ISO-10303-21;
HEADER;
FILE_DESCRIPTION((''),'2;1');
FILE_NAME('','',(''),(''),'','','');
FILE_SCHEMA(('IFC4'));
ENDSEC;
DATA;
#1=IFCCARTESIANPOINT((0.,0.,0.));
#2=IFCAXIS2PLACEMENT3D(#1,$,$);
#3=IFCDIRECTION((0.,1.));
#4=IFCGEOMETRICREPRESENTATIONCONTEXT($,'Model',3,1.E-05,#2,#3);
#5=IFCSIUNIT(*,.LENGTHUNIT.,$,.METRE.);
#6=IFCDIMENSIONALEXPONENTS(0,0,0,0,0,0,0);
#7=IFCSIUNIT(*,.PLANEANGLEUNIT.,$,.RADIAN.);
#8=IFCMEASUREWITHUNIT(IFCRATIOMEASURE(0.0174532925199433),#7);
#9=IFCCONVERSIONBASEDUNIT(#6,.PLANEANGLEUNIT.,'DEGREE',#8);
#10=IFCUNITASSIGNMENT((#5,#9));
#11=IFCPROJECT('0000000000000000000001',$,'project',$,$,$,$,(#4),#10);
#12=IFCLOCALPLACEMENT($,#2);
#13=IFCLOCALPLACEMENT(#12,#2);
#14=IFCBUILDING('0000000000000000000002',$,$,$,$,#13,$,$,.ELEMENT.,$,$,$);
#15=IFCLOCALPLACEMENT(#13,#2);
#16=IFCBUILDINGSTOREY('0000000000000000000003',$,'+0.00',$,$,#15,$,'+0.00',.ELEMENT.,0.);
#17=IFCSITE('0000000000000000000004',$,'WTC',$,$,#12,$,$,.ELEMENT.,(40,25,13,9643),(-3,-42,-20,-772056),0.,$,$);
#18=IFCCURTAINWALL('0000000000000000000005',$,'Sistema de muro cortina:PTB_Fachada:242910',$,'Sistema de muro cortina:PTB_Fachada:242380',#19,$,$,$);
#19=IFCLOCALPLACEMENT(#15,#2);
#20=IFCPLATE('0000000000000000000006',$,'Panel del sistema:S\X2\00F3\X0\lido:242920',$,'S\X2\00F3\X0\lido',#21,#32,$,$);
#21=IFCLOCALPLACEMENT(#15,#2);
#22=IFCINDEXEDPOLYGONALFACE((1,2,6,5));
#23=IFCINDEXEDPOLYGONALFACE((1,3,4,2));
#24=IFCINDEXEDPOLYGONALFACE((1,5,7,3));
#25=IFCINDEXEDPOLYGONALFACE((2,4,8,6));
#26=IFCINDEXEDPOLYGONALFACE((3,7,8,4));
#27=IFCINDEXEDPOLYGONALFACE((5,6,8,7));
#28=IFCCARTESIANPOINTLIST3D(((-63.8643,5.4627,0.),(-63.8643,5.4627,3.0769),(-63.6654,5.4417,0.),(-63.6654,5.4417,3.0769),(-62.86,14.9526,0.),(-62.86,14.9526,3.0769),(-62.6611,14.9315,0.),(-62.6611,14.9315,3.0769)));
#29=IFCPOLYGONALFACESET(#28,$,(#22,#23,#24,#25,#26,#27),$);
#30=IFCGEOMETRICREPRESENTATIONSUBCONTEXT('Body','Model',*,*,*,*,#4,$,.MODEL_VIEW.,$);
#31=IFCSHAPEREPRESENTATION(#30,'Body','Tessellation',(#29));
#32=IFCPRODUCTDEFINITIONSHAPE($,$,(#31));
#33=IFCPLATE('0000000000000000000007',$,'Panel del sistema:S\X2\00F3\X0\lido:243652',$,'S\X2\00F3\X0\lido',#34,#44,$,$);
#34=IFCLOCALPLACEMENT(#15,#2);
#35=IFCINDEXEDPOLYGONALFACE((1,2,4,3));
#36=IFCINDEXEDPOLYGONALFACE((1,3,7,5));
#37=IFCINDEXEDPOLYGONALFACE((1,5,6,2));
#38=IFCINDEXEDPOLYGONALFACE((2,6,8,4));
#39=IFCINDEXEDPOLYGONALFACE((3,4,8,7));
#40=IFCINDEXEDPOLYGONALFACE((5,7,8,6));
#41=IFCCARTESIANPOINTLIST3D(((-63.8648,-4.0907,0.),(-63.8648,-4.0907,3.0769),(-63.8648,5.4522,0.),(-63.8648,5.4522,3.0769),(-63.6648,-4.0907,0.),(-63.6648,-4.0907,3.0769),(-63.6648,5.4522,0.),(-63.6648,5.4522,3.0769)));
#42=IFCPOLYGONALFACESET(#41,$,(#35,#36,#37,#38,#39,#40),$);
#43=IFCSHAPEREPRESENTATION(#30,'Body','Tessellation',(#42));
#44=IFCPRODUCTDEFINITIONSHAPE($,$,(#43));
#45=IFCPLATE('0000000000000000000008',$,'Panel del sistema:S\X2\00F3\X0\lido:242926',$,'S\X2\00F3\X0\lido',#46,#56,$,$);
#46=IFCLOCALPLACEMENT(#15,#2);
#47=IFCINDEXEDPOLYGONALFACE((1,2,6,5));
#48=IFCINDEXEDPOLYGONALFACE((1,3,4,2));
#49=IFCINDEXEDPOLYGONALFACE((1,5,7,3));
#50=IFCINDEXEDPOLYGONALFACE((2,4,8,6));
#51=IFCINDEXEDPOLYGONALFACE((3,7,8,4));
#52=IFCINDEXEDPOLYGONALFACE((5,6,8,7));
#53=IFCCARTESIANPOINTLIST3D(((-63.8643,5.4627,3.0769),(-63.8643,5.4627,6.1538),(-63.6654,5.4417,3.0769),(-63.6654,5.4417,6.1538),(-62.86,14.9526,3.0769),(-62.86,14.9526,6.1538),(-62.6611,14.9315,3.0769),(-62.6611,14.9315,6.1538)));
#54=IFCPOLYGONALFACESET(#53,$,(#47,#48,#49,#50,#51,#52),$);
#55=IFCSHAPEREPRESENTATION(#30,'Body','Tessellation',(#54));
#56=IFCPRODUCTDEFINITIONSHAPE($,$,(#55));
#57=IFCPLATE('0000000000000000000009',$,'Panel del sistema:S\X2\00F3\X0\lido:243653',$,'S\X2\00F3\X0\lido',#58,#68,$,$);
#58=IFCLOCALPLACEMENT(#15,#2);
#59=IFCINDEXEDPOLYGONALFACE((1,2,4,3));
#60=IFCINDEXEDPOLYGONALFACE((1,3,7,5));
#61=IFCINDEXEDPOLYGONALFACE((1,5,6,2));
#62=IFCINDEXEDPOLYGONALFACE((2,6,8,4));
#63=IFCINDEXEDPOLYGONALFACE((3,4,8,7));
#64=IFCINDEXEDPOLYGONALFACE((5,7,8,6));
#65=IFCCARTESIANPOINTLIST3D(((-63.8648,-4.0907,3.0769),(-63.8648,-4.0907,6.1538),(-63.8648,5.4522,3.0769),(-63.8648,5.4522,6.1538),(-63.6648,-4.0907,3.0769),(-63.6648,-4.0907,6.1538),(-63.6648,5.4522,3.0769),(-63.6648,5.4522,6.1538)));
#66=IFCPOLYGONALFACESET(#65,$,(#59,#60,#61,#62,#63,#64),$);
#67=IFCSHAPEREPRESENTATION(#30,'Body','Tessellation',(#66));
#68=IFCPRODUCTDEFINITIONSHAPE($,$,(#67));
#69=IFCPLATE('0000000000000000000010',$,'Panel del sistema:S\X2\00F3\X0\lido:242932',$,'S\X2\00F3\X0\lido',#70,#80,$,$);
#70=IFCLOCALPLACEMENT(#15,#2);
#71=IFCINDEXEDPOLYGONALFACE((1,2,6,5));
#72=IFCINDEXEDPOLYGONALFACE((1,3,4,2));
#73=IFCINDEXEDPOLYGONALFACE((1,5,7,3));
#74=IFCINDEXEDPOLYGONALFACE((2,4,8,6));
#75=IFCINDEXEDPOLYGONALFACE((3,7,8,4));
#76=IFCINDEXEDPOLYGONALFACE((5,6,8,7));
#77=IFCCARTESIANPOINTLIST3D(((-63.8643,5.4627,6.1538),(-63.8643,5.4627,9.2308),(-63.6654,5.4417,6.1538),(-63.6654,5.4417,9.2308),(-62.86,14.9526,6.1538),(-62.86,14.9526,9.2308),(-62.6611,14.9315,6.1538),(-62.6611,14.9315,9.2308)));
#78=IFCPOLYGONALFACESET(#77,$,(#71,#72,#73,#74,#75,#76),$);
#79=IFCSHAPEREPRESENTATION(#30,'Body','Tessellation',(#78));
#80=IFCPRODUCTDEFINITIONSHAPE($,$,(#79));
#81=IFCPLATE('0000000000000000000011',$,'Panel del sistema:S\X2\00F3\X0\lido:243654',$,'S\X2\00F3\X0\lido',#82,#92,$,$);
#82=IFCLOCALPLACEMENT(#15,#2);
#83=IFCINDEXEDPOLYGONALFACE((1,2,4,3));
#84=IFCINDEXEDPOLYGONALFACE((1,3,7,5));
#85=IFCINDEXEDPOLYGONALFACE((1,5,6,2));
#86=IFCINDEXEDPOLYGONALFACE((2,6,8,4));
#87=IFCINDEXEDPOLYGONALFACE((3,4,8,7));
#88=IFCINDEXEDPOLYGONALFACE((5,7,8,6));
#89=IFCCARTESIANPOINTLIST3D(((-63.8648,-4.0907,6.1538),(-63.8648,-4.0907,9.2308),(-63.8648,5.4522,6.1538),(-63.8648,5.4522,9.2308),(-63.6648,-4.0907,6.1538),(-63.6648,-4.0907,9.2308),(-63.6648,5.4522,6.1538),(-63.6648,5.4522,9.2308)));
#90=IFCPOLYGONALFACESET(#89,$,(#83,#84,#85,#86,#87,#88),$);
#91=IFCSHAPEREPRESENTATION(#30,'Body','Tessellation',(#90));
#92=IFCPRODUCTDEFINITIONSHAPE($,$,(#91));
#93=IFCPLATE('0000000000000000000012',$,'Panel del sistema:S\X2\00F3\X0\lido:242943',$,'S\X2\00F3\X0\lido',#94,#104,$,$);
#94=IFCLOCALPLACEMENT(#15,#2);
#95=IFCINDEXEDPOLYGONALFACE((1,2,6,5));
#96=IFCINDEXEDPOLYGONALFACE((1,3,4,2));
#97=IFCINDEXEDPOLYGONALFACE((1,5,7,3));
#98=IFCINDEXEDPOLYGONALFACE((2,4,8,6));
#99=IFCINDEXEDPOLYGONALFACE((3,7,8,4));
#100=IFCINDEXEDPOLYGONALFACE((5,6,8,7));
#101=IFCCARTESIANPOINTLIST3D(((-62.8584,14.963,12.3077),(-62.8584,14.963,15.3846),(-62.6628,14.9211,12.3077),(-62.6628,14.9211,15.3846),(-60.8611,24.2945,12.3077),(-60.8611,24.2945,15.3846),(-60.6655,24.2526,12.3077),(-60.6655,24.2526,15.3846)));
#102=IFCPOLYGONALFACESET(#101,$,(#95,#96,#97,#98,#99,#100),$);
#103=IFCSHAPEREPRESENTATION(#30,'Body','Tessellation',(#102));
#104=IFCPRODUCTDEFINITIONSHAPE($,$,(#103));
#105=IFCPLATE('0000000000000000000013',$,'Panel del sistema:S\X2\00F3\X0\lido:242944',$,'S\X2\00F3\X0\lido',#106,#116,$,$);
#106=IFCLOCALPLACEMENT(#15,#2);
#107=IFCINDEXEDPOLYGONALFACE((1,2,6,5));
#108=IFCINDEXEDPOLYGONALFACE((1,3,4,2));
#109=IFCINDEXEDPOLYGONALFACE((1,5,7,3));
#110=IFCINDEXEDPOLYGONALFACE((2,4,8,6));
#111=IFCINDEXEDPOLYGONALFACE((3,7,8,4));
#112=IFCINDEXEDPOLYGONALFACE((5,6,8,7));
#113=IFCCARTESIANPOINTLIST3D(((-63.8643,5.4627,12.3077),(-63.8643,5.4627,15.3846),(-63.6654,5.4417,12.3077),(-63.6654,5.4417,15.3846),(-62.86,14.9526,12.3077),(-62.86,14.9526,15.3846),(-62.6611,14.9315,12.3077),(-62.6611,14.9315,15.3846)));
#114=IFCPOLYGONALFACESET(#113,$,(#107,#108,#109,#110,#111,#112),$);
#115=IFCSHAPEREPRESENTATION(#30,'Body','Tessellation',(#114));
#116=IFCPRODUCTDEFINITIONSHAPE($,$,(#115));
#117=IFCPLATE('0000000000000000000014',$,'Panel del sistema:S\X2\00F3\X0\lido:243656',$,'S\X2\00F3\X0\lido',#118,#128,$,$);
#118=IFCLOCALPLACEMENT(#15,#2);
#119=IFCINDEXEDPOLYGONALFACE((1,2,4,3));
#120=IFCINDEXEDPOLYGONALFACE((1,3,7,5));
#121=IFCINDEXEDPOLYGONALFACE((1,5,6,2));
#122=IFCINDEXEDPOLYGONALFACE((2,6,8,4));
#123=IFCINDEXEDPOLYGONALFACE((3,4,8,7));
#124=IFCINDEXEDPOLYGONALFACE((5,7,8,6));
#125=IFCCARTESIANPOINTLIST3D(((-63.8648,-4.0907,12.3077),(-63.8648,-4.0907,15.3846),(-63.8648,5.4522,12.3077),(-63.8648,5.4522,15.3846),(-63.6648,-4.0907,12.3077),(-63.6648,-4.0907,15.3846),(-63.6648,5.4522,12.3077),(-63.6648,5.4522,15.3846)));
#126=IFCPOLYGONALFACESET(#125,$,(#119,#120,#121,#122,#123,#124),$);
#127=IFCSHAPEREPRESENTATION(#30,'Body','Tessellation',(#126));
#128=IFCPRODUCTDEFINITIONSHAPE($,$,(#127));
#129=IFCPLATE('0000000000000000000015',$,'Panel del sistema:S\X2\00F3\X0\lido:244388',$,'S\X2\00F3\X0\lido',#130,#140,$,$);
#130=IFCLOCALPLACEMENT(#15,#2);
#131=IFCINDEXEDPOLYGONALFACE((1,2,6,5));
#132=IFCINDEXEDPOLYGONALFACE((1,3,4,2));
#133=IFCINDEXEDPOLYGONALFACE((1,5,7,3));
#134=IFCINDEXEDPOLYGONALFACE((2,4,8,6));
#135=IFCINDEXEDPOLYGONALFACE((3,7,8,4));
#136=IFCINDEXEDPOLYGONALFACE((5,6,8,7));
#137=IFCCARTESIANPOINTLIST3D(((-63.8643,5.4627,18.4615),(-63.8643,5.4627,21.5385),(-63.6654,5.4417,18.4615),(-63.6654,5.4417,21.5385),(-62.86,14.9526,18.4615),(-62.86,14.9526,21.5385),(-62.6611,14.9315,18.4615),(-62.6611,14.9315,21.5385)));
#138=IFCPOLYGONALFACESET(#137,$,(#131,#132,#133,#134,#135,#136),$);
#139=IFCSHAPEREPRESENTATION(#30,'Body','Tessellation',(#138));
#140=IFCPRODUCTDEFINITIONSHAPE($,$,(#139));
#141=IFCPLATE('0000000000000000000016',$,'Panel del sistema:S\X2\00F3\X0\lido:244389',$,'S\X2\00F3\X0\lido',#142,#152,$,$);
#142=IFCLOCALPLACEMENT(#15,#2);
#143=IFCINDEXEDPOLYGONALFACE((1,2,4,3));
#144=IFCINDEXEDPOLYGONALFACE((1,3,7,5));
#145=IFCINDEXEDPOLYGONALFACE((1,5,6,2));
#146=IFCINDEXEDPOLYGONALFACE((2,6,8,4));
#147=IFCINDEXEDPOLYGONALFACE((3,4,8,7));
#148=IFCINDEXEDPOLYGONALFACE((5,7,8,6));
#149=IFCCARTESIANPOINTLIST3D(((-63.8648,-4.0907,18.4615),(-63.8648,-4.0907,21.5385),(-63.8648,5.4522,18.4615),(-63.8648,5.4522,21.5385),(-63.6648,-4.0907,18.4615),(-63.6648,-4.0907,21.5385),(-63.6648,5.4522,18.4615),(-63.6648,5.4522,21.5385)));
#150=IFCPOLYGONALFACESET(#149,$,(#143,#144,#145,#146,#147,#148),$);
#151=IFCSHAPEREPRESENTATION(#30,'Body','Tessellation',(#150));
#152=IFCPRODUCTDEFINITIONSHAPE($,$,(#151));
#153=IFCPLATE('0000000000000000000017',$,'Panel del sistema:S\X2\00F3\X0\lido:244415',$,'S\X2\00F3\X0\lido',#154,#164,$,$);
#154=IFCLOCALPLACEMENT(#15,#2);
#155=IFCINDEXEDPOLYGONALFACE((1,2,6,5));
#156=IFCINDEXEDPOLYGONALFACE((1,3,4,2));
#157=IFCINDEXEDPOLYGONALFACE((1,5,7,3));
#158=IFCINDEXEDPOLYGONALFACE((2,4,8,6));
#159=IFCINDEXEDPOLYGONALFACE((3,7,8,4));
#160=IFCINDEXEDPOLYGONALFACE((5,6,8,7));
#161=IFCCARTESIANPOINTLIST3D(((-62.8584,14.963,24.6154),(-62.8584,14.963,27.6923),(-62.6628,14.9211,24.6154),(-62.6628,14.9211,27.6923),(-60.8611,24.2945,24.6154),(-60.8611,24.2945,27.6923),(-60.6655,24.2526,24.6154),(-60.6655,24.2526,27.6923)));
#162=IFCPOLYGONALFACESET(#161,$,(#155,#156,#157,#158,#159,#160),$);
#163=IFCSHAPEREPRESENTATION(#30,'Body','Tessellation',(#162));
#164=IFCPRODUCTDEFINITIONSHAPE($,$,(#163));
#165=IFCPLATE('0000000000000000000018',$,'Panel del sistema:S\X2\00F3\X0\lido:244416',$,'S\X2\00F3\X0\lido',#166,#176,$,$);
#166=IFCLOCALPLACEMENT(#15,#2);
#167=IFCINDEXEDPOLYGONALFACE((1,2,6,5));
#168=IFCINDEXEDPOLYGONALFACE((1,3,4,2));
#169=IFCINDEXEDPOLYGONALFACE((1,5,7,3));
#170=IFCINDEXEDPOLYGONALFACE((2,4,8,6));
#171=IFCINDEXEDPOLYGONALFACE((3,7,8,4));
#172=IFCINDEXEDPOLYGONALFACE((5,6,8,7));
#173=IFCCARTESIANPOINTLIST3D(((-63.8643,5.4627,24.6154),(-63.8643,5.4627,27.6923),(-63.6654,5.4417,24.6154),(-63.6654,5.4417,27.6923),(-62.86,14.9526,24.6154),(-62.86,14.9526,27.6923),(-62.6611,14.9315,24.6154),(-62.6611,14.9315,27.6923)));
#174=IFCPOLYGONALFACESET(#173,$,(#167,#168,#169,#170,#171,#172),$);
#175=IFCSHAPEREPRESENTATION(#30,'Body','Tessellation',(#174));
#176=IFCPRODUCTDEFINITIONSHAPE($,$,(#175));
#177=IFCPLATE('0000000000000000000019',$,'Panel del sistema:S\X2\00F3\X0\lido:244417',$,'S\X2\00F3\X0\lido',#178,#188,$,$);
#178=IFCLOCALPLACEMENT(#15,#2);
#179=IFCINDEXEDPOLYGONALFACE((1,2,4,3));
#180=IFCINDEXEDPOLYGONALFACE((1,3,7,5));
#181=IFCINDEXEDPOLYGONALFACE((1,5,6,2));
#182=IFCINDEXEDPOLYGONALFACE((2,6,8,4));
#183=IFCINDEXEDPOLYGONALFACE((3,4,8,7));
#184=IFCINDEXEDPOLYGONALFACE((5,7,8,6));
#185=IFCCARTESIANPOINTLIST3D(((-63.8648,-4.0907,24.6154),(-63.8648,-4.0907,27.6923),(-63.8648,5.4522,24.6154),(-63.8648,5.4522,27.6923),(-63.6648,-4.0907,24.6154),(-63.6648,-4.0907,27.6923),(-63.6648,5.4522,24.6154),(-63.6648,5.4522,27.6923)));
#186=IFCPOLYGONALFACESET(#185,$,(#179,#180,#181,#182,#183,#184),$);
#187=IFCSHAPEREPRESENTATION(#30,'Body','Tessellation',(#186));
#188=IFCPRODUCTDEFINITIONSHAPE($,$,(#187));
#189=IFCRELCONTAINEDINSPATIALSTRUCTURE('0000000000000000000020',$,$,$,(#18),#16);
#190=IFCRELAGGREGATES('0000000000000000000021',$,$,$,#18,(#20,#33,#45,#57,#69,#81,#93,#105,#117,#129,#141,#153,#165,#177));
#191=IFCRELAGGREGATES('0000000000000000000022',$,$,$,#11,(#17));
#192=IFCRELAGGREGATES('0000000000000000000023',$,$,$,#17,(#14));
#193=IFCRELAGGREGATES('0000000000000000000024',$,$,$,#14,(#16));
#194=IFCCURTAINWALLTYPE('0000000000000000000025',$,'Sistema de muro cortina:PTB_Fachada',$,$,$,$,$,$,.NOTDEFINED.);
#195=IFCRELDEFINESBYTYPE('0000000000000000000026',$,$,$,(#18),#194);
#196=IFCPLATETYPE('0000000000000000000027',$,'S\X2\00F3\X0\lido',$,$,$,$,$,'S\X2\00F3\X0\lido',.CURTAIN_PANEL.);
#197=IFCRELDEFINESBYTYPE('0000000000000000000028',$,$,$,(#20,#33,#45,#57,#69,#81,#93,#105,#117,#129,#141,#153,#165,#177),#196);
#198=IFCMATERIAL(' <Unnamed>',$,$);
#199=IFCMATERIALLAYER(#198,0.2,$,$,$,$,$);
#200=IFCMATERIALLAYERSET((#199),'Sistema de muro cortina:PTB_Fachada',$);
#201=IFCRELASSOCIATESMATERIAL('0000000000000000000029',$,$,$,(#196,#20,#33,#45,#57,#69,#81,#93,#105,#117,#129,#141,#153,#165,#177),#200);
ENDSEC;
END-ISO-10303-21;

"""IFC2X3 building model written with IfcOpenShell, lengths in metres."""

from ifc_helpers import new_model, entity, si_unit, converted_unit, direction, frame, frame_2d, origin, place, context, subcontext, project, spatial, rectangle, extrude, source, transform, mapped, material, layer, layer_set, layer_usage, type_object, type_shapes, element, aggregate, save


model = new_model("IFC2X3")

# Units and contexts
model_context = context("Model", 3, precision=1e-05, world=origin(), true_north=direction((0.0, 1.0)))
body_context = subcontext(model_context, "Body", "Model", "MODEL_VIEW")
ifc_project = project(units=[si_unit("LENGTHUNIT", "METRE"), converted_unit("PLANEANGLEUNIT", "DEGREE", entity("IfcRatioMeasure", 0.0174532925199433), si_unit("PLANEANGLEUNIT", "RADIAN"), dimensions=[0, 0, 0, 0, 0, 0, 0])], contexts=[model_context])

# Site, building, storey
site_placement = place(None, origin())
site = spatial("IfcSite", under=ifc_project, at=site_placement, Name="WTC", CompositionType="ELEMENT", RefLatitude=(40, 25, 13, 9643), RefLongitude=(-3, -42, -20, -772056), RefElevation=0.0)
building_placement = place(site_placement, origin())
building = spatial("IfcBuilding", under=site, at=building_placement, CompositionType="ELEMENT")
storey_placement = place(building_placement, origin())
storey = spatial("IfcBuildingStorey", under=building, at=storey_placement, Name="+0.00", LongName="+0.00", CompositionType="ELEMENT", Elevation=0.0)

# Curtain wall, plates
curtain_wall_type = type_object("IfcCurtainWallType", Name="Sistema de muro cortina:PTB_Fachada", PredefinedType="NOTDEFINED")
curtain_wall_placement = place(storey_placement, origin())
curtain_wall = element("IfcCurtainWall", 1, at=curtain_wall_placement, inside=storey, type_object=curtain_wall_type, Name="Sistema de muro cortina:PTB_Fachada:242910", ObjectType="Sistema de muro cortina:PTB_Fachada:242380")
ifc_material_1 = material(Name=" <Unnamed>")
ifc_layer_1 = layer(ifc_material_1, 0.2)
ifc_layer_set_1 = layer_set([ifc_layer_1], Name="Sistema de muro cortina:PTB_Fachada")
ifc_layer_usage_1 = layer_usage(ifc_layer_set_1, "AXIS3", "POSITIVE", 0.0)
plate_type_1 = type_object("IfcPlateType", Name="Sólido", ElementType="Sólido", PredefinedType="CURTAIN_PANEL", material=ifc_layer_set_1)
shared_shape_1 = source(origin(), body_context, "Body", "SweptSolid", [
    extrude(rectangle(XDim=0.2, YDim=9.5428, at=frame_2d((0.0, 0.0), x_axis=(1.0, 0.0))), frame((0.0, 0.0, 0.0), z_axis=(0.0, 0.0, 1.0), x_axis=(0.0, 1.0, 0.0)), (0.0, 0.0, 1.0), 3.0769),
])
type_shapes(plate_type_1, [shared_shape_1])
plate_1_placement = place(curtain_wall_placement, frame((-63.2627, 10.1971, 0.0), z_axis=(0.0, 0.0, 1.0), x_axis=(-0.105232, -0.994448, 0.0)))
plate_1 = element("IfcPlate", 2, at=plate_1_placement, type_object=plate_type_1, material=ifc_layer_usage_1, Name="Panel del sistema:Sólido:242920", ObjectType="Sólido", context=body_context, shape_type="MappedRepresentation", body=[
    mapped(shared_shape_1, transform((0.0, 0.0, 0.0), scale=1.0)),
])
ifc_layer_usage_2 = layer_usage(ifc_layer_set_1, "AXIS3", "POSITIVE", 0.0)
plate_2_placement = place(curtain_wall_placement, frame((-63.7648, 0.6808, 0.0), z_axis=(0.0, 0.0, 1.0), x_axis=(0.0, -1.0, 0.0)))
plate_2 = element("IfcPlate", 3, at=plate_2_placement, type_object=plate_type_1, material=ifc_layer_usage_2, Name="Panel del sistema:Sólido:243652", ObjectType="Sólido", context=body_context, shape_type="MappedRepresentation", body=[
    mapped(shared_shape_1, transform((0.0, 0.0, 0.0), scale=1.0)),
])
ifc_layer_usage_3 = layer_usage(ifc_layer_set_1, "AXIS3", "POSITIVE", 0.0)
plate_3_placement = place(curtain_wall_placement, frame((-63.2627, 10.1971, 3.0769), z_axis=(0.0, 0.0, 1.0), x_axis=(-0.105232, -0.994448, 0.0)))
plate_3 = element("IfcPlate", 4, at=plate_3_placement, type_object=plate_type_1, material=ifc_layer_usage_3, Name="Panel del sistema:Sólido:242926", ObjectType="Sólido", context=body_context, shape_type="MappedRepresentation", body=[
    mapped(shared_shape_1, transform((0.0, 0.0, 0.0), scale=1.0)),
])
ifc_layer_usage_4 = layer_usage(ifc_layer_set_1, "AXIS3", "POSITIVE", 0.0)
plate_4_placement = place(curtain_wall_placement, frame((-63.7648, 0.6808, 3.0769), z_axis=(0.0, 0.0, 1.0), x_axis=(0.0, -1.0, 0.0)))
plate_4 = element("IfcPlate", 5, at=plate_4_placement, type_object=plate_type_1, material=ifc_layer_usage_4, Name="Panel del sistema:Sólido:243653", ObjectType="Sólido", context=body_context, shape_type="MappedRepresentation", body=[
    mapped(shared_shape_1, transform((0.0, 0.0, 0.0), scale=1.0)),
])
ifc_layer_usage_5 = layer_usage(ifc_layer_set_1, "AXIS3", "POSITIVE", 0.0)
plate_5_placement = place(curtain_wall_placement, frame((-63.2627, 10.1971, 6.1538), z_axis=(0.0, 0.0, 1.0), x_axis=(-0.105232, -0.994448, 0.0)))
plate_5 = element("IfcPlate", 6, at=plate_5_placement, type_object=plate_type_1, material=ifc_layer_usage_5, Name="Panel del sistema:Sólido:242932", ObjectType="Sólido", context=body_context, shape_type="MappedRepresentation", body=[
    mapped(shared_shape_1, transform((0.0, 0.0, 0.0), scale=1.0)),
])
ifc_layer_usage_6 = layer_usage(ifc_layer_set_1, "AXIS3", "POSITIVE", 0.0)
plate_6_placement = place(curtain_wall_placement, frame((-63.7648, 0.6808, 6.1538), z_axis=(0.0, 0.0, 1.0), x_axis=(0.0, -1.0, 0.0)))
plate_6 = element("IfcPlate", 7, at=plate_6_placement, type_object=plate_type_1, material=ifc_layer_usage_6, Name="Panel del sistema:Sólido:243654", ObjectType="Sólido", context=body_context, shape_type="MappedRepresentation", body=[
    mapped(shared_shape_1, transform((0.0, 0.0, 0.0), scale=1.0)),
])
ifc_layer_usage_7 = layer_usage(ifc_layer_set_1, "AXIS3", "POSITIVE", 0.0)
plate_7_placement = place(curtain_wall_placement, frame((-61.762, 19.6078, 12.3077), z_axis=(0.0, 0.0, 1.0), x_axis=(-0.209296, -0.977852, 0.0)))
plate_7 = element("IfcPlate", 8, at=plate_7_placement, type_object=plate_type_1, material=ifc_layer_usage_7, Name="Panel del sistema:Sólido:242943", ObjectType="Sólido", context=body_context, shape_type="MappedRepresentation", body=[
    mapped(shared_shape_1, transform((0.0, 0.0, 0.0), scale=1.0)),
])
ifc_layer_usage_8 = layer_usage(ifc_layer_set_1, "AXIS3", "POSITIVE", 0.0)
plate_8_placement = place(curtain_wall_placement, frame((-63.2627, 10.1971, 12.3077), z_axis=(0.0, 0.0, 1.0), x_axis=(-0.105232, -0.994448, 0.0)))
plate_8 = element("IfcPlate", 9, at=plate_8_placement, type_object=plate_type_1, material=ifc_layer_usage_8, Name="Panel del sistema:Sólido:242944", ObjectType="Sólido", context=body_context, shape_type="MappedRepresentation", body=[
    mapped(shared_shape_1, transform((0.0, 0.0, 0.0), scale=1.0)),
])
ifc_layer_usage_9 = layer_usage(ifc_layer_set_1, "AXIS3", "POSITIVE", 0.0)
plate_9_placement = place(curtain_wall_placement, frame((-63.7648, 0.6808, 12.3077), z_axis=(0.0, 0.0, 1.0), x_axis=(0.0, -1.0, 0.0)))
plate_9 = element("IfcPlate", 10, at=plate_9_placement, type_object=plate_type_1, material=ifc_layer_usage_9, Name="Panel del sistema:Sólido:243656", ObjectType="Sólido", context=body_context, shape_type="MappedRepresentation", body=[
    mapped(shared_shape_1, transform((0.0, 0.0, 0.0), scale=1.0)),
])
ifc_layer_usage_10 = layer_usage(ifc_layer_set_1, "AXIS3", "POSITIVE", 0.0)
plate_10_placement = place(curtain_wall_placement, frame((-63.2627, 10.1971, 18.4615), z_axis=(0.0, 0.0, 1.0), x_axis=(-0.105232, -0.994448, 0.0)))
plate_10 = element("IfcPlate", 11, at=plate_10_placement, type_object=plate_type_1, material=ifc_layer_usage_10, Name="Panel del sistema:Sólido:244388", ObjectType="Sólido", context=body_context, shape_type="MappedRepresentation", body=[
    mapped(shared_shape_1, transform((0.0, 0.0, 0.0), scale=1.0)),
])
ifc_layer_usage_11 = layer_usage(ifc_layer_set_1, "AXIS3", "POSITIVE", 0.0)
plate_11_placement = place(curtain_wall_placement, frame((-63.7648, 0.6808, 18.4615), z_axis=(0.0, 0.0, 1.0), x_axis=(0.0, -1.0, 0.0)))
plate_11 = element("IfcPlate", 12, at=plate_11_placement, type_object=plate_type_1, material=ifc_layer_usage_11, Name="Panel del sistema:Sólido:244389", ObjectType="Sólido", context=body_context, shape_type="MappedRepresentation", body=[
    mapped(shared_shape_1, transform((0.0, 0.0, 0.0), scale=1.0)),
])
ifc_layer_usage_12 = layer_usage(ifc_layer_set_1, "AXIS3", "POSITIVE", 0.0)
plate_12_placement = place(curtain_wall_placement, frame((-61.762, 19.6078, 24.6154), z_axis=(0.0, 0.0, 1.0), x_axis=(-0.209296, -0.977852, 0.0)))
plate_12 = element("IfcPlate", 13, at=plate_12_placement, type_object=plate_type_1, material=ifc_layer_usage_12, Name="Panel del sistema:Sólido:244415", ObjectType="Sólido", context=body_context, shape_type="MappedRepresentation", body=[
    mapped(shared_shape_1, transform((0.0, 0.0, 0.0), scale=1.0)),
])
ifc_layer_usage_13 = layer_usage(ifc_layer_set_1, "AXIS3", "POSITIVE", 0.0)
plate_13_placement = place(curtain_wall_placement, frame((-63.2627, 10.1971, 24.6154), z_axis=(0.0, 0.0, 1.0), x_axis=(-0.105232, -0.994448, 0.0)))
plate_13 = element("IfcPlate", 14, at=plate_13_placement, type_object=plate_type_1, material=ifc_layer_usage_13, Name="Panel del sistema:Sólido:244416", ObjectType="Sólido", context=body_context, shape_type="MappedRepresentation", body=[
    mapped(shared_shape_1, transform((0.0, 0.0, 0.0), scale=1.0)),
])
ifc_layer_usage_14 = layer_usage(ifc_layer_set_1, "AXIS3", "POSITIVE", 0.0)
plate_14_placement = place(curtain_wall_placement, frame((-63.7648, 0.6808, 24.6154), z_axis=(0.0, 0.0, 1.0), x_axis=(0.0, -1.0, 0.0)))
plate_14 = element("IfcPlate", 15, at=plate_14_placement, type_object=plate_type_1, material=ifc_layer_usage_14, Name="Panel del sistema:Sólido:244417", ObjectType="Sólido", context=body_context, shape_type="MappedRepresentation", body=[
    mapped(shared_shape_1, transform((0.0, 0.0, 0.0), scale=1.0)),
])
aggregate(curtain_wall, [plate_1, plate_2, plate_3, plate_4, plate_5, plate_6, plate_7, plate_8, plate_9, plate_10, plate_11, plate_12, plate_13, plate_14])

save(model, "model.ifc")
